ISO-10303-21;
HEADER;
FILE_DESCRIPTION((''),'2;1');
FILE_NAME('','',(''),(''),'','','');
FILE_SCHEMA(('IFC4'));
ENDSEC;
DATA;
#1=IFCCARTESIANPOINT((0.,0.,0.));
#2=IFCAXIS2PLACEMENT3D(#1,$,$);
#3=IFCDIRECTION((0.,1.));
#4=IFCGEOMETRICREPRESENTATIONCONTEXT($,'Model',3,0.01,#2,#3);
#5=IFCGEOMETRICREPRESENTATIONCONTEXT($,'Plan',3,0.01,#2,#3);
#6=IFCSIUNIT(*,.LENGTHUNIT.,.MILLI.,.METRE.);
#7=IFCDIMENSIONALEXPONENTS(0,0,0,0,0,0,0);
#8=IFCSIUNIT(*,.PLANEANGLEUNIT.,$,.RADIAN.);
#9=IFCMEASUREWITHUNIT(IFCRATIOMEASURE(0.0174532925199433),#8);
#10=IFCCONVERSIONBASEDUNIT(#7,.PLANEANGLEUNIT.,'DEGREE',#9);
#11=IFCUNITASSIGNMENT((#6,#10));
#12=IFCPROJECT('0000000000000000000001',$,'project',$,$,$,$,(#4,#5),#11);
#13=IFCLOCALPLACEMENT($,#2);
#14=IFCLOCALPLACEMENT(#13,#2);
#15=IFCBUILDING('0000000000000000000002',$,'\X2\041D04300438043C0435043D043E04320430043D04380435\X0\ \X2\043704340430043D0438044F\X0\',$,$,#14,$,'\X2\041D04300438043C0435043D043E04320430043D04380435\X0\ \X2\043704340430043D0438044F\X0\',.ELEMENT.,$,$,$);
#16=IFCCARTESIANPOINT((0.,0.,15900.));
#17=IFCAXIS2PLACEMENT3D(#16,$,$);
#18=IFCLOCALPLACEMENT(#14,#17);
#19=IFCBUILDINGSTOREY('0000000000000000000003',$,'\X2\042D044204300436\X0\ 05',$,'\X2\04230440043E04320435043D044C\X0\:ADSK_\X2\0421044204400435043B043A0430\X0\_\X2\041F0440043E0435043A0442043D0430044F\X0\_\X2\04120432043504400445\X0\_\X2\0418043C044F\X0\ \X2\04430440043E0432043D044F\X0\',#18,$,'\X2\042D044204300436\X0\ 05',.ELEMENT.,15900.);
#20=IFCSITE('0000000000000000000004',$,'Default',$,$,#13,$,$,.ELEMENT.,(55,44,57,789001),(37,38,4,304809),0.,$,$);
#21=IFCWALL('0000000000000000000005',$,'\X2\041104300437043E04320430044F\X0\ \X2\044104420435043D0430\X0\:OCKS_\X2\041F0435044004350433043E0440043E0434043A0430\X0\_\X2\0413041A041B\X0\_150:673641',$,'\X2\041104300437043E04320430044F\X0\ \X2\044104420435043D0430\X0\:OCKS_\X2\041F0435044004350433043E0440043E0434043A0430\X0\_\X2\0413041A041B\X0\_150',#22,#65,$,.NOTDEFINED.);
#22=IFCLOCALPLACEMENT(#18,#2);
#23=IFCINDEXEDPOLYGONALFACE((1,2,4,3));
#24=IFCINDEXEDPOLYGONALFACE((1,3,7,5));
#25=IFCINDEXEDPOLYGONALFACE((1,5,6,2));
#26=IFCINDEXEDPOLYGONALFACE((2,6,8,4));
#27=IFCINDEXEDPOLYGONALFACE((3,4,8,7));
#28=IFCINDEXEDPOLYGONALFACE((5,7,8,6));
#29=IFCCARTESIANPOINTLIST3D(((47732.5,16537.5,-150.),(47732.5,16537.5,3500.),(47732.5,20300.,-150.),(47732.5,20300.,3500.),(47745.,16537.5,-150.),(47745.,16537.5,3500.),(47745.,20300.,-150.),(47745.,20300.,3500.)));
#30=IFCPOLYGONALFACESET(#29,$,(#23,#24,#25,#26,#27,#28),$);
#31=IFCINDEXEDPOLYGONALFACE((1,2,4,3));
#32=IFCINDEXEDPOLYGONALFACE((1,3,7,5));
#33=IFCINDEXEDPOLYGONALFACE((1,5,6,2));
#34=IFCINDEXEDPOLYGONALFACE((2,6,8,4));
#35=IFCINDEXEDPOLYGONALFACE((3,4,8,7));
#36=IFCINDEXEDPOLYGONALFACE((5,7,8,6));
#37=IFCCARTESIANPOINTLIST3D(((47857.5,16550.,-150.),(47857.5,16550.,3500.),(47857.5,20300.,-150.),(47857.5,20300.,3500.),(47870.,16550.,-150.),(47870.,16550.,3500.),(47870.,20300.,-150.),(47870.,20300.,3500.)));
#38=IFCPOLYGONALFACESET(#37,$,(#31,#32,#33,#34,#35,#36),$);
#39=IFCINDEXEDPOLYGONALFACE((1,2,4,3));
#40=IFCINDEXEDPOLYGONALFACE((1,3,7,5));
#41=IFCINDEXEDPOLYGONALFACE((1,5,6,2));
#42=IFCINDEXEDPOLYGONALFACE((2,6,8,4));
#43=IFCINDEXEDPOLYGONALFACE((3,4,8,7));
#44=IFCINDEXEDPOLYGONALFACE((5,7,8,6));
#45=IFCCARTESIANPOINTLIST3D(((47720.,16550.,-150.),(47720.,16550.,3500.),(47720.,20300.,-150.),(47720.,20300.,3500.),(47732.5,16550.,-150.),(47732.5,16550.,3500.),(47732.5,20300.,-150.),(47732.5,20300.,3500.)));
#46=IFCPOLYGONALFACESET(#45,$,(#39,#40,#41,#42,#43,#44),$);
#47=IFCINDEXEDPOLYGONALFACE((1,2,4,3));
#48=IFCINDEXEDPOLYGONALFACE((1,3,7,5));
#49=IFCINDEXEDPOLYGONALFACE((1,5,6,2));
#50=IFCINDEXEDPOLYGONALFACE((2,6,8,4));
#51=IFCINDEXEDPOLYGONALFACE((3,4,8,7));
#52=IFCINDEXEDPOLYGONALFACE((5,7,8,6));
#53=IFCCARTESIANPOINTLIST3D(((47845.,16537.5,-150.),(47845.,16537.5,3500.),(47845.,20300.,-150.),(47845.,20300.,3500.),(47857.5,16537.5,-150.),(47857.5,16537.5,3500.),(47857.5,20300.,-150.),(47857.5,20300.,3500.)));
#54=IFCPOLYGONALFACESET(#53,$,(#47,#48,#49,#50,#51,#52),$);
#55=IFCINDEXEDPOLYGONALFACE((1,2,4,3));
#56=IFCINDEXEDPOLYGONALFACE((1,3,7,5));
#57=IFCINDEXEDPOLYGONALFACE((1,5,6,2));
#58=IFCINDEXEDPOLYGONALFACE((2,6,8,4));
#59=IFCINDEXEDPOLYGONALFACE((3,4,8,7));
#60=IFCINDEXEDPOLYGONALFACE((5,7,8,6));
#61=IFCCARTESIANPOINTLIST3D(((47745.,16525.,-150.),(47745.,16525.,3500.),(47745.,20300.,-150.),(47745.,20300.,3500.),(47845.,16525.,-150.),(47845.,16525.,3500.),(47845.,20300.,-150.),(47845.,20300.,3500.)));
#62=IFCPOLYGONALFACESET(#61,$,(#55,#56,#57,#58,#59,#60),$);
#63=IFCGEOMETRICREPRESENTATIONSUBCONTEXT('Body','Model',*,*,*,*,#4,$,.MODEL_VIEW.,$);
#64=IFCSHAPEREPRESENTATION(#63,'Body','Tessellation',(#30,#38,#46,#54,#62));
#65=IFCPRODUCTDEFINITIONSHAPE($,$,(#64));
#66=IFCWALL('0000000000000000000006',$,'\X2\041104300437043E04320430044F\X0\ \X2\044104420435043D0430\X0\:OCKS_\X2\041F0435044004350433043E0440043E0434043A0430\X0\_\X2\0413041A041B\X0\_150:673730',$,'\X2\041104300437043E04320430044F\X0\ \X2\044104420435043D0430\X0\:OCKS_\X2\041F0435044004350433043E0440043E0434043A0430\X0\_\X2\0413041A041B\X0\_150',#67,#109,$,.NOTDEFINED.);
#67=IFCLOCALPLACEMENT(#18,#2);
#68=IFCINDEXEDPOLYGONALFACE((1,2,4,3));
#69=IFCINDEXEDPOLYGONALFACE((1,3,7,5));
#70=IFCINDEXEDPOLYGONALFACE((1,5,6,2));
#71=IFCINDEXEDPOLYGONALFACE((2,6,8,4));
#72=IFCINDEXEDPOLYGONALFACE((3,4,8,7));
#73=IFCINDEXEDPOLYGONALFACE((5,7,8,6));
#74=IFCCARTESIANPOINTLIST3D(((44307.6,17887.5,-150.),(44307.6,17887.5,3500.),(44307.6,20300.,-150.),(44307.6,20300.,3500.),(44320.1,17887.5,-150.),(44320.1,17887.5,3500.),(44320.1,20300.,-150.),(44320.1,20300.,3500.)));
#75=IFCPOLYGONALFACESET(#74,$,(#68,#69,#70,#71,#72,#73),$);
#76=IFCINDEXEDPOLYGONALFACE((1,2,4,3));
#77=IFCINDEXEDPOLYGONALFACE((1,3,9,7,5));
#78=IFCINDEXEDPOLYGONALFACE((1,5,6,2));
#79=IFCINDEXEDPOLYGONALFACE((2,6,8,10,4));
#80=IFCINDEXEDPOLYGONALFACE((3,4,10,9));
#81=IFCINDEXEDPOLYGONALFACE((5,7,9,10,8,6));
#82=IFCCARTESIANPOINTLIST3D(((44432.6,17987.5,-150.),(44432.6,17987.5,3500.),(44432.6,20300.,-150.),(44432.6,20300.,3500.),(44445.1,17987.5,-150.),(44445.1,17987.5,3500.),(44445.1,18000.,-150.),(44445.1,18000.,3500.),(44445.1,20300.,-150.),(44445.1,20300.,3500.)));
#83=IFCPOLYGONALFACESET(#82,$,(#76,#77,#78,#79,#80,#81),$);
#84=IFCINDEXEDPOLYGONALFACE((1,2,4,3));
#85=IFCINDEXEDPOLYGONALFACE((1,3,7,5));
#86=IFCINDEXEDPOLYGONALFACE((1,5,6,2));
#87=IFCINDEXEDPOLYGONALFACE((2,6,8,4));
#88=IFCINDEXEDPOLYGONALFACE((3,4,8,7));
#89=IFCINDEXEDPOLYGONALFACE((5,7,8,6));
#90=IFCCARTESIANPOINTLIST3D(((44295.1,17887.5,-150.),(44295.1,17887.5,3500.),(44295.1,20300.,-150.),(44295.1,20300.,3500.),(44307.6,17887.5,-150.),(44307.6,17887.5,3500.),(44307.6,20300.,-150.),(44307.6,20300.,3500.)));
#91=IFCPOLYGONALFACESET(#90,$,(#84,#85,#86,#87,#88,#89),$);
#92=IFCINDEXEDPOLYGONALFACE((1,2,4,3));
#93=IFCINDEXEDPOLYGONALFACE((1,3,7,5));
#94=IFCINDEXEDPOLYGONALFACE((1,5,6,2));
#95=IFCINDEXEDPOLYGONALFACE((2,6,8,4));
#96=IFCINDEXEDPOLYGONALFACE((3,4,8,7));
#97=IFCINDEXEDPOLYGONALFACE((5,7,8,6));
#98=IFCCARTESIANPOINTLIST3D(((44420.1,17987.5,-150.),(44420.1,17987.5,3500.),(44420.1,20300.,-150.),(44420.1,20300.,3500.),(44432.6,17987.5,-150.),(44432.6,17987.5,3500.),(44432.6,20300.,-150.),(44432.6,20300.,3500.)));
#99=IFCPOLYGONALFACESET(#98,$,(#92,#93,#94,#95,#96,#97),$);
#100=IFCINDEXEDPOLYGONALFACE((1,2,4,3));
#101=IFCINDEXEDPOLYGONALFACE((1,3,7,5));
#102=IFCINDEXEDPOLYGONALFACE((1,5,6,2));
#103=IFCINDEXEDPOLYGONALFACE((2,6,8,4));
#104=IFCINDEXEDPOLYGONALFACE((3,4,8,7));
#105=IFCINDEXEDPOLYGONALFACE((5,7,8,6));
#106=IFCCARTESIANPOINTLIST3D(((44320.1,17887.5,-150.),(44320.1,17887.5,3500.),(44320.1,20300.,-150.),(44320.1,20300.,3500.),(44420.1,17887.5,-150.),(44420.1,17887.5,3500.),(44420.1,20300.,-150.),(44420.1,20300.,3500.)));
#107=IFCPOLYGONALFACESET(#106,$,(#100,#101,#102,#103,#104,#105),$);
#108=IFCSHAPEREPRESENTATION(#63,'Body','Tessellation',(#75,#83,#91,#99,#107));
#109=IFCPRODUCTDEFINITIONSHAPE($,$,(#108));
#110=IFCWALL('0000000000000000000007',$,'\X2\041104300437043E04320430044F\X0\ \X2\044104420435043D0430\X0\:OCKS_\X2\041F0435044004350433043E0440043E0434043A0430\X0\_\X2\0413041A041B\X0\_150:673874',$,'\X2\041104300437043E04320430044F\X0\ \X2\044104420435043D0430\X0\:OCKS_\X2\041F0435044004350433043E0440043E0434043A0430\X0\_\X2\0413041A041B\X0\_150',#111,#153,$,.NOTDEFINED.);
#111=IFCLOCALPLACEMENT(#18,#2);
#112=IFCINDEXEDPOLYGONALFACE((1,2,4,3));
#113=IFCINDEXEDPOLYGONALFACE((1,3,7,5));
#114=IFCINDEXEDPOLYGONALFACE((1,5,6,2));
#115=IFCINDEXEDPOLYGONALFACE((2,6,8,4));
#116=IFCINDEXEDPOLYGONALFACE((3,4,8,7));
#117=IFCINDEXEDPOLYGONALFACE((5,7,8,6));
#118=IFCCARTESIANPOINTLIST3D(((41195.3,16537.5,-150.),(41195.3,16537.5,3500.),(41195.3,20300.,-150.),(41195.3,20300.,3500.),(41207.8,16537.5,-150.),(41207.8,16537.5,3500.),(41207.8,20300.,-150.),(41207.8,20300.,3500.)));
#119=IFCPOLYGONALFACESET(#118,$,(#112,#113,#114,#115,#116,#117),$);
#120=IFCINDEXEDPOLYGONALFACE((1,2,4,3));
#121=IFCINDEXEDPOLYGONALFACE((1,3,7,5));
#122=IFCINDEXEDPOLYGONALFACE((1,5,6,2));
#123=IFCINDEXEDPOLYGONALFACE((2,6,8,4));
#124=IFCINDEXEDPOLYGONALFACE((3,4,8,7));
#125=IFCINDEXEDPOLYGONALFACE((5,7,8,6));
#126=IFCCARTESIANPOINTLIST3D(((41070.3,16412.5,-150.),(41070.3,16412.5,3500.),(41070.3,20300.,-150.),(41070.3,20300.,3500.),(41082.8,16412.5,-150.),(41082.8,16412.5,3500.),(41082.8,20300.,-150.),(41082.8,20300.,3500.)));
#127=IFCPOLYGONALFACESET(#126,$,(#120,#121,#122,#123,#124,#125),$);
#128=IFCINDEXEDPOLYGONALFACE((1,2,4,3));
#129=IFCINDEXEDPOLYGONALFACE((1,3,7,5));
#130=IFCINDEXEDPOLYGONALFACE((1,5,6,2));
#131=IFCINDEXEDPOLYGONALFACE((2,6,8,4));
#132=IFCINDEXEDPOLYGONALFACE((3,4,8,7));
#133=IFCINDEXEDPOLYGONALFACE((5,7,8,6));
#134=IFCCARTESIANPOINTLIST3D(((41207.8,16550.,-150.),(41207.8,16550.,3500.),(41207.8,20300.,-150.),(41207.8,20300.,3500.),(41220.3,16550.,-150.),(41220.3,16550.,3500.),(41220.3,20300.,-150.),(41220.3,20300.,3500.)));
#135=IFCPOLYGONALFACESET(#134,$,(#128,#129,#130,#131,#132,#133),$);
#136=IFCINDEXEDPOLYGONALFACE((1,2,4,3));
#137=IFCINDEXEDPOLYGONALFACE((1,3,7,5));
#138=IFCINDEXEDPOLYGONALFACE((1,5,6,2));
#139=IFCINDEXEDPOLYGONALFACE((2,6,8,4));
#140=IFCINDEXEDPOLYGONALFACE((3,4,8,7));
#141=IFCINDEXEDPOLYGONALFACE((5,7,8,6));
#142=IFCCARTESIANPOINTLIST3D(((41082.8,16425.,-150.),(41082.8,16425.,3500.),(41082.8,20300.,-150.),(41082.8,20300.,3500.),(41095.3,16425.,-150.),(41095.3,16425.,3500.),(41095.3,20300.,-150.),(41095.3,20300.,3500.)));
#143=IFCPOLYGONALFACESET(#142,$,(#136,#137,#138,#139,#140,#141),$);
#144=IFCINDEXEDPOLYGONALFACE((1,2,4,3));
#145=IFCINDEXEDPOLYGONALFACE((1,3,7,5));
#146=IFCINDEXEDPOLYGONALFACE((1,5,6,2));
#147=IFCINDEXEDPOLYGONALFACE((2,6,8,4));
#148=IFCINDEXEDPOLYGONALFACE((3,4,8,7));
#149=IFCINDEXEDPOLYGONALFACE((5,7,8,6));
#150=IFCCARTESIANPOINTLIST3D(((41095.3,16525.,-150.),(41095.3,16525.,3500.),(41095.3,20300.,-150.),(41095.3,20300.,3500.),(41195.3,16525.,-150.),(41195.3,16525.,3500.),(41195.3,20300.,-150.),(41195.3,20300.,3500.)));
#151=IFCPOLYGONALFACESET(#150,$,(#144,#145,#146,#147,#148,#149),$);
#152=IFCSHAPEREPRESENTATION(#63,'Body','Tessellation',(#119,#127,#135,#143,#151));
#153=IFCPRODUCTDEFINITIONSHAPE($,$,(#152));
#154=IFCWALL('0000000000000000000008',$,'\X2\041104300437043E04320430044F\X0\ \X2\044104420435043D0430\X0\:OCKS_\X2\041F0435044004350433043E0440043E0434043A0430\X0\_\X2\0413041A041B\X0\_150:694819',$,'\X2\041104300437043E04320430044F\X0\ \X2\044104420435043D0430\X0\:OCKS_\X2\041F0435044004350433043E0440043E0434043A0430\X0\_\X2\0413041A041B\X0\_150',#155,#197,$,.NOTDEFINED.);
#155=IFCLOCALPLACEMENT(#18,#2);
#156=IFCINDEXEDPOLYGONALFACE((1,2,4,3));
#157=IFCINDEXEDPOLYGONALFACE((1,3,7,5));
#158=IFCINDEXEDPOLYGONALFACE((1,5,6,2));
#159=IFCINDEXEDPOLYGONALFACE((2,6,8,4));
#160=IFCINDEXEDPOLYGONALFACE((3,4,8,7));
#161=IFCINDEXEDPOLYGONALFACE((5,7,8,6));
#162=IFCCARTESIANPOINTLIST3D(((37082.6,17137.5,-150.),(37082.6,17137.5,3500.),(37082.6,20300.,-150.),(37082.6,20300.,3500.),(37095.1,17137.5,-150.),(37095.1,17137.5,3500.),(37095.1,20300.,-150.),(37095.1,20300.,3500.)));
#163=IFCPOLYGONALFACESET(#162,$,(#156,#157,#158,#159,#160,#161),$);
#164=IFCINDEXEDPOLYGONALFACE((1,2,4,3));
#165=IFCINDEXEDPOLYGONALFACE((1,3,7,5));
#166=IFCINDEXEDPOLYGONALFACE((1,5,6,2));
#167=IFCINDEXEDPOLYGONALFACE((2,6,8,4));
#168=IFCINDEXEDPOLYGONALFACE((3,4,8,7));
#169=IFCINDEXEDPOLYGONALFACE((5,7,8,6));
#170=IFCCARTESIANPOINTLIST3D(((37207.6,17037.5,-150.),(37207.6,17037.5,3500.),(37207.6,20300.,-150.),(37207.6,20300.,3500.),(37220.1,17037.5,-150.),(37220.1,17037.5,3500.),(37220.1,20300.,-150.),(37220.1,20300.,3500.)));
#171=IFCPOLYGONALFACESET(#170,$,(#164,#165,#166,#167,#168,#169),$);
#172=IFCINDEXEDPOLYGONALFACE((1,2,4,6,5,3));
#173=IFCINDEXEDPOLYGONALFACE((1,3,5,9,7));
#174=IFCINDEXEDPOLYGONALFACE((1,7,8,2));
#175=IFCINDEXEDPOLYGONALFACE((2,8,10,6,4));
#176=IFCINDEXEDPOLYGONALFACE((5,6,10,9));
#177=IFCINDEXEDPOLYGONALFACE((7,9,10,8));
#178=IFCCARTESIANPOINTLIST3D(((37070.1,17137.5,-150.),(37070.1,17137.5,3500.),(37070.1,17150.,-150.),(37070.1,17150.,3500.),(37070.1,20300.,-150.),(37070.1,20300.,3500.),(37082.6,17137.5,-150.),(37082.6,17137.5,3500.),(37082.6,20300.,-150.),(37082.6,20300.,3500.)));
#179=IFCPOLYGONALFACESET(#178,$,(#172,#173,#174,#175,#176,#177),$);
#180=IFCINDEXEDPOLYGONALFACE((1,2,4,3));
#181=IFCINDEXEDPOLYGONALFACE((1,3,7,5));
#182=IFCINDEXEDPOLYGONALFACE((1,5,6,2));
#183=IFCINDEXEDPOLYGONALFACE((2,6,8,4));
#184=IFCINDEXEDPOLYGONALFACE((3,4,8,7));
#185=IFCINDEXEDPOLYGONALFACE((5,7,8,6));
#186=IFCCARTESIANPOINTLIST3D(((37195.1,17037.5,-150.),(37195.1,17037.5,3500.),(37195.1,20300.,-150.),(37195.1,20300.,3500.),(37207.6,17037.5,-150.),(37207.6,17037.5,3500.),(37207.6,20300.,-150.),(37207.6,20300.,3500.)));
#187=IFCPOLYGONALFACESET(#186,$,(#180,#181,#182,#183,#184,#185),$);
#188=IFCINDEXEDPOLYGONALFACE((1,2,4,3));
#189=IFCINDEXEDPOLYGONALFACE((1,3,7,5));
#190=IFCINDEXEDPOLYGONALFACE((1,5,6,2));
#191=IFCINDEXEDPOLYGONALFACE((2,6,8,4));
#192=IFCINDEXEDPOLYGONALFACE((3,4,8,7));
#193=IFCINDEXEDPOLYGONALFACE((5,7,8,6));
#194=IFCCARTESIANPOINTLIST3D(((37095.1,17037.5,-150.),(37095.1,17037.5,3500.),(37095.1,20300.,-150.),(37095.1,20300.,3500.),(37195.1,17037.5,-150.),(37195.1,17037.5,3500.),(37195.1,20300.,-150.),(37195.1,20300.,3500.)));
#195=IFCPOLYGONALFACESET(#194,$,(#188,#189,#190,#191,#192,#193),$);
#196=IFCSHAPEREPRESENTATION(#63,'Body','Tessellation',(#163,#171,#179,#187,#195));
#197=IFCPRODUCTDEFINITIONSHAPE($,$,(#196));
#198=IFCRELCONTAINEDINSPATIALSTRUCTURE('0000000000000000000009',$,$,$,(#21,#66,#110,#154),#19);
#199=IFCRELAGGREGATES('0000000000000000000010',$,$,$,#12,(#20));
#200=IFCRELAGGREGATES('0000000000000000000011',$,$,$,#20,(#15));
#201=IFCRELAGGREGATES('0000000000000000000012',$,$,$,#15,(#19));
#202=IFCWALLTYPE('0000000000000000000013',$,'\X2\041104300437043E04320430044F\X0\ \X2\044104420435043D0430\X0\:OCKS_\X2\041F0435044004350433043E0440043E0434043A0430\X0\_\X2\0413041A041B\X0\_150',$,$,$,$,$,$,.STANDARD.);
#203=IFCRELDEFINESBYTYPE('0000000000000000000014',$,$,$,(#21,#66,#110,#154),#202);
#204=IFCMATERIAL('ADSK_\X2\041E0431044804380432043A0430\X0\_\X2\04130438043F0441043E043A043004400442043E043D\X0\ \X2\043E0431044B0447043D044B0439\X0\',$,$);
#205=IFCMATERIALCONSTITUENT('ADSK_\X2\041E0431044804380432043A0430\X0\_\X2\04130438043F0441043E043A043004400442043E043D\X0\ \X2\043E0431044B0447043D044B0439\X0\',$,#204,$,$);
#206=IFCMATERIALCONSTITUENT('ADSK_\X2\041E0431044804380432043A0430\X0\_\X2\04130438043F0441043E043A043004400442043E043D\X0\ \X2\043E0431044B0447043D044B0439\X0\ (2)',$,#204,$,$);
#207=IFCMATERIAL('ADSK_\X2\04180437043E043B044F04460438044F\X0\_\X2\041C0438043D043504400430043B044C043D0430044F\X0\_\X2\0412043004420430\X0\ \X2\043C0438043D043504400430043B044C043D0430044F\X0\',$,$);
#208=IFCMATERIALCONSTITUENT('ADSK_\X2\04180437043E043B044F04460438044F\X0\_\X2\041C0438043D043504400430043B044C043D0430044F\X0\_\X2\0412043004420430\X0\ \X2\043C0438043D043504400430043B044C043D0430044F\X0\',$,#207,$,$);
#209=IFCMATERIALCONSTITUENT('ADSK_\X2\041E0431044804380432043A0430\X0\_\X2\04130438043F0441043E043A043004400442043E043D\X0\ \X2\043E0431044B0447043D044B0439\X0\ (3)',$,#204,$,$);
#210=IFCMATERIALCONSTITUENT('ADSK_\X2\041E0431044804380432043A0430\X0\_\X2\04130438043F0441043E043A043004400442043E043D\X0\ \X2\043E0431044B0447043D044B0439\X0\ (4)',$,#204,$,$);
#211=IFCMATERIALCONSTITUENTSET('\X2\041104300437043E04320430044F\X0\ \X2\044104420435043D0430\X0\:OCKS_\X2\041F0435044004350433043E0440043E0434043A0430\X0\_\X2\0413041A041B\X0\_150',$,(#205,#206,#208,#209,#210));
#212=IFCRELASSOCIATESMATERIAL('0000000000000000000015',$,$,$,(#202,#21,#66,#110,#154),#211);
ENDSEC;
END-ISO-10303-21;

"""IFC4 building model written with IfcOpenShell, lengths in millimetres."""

from ifc_helpers import new_model, entity, si_unit, converted_unit, direction, frame, origin, place, context, subcontext, project, spatial, indexed_curve, outline, extrude, material, constituent, constituent_set, type_object, element, save


model = new_model("IFC4")

# Units and contexts
model_context = context("Model", 3, precision=0.01, world=origin(), true_north=direction((0.0, 1.0)))
plan_context = context("Plan", 3, precision=0.01, world=origin(), true_north=direction((0.0, 1.0)))
body_context = subcontext(model_context, "Body", "Model", "MODEL_VIEW")
ifc_project = project(units=[si_unit("LENGTHUNIT", "METRE", prefix="MILLI"), converted_unit("PLANEANGLEUNIT", "DEGREE", entity("IfcRatioMeasure", 0.0174532925199433), si_unit("PLANEANGLEUNIT", "RADIAN"), dimensions=[0, 0, 0, 0, 0, 0, 0])], contexts=[model_context, plan_context])

# Site, building, storey
site_placement = place(None, frame((0.0, 0.0, 0.0)))
site = spatial("IfcSite", under=ifc_project, at=site_placement, Name="Default", CompositionType="ELEMENT", RefLatitude=(55, 44, 57, 789001), RefLongitude=(37, 38, 4, 304809), RefElevation=0.0)
building_placement = place(site_placement, origin())
building = spatial("IfcBuilding", under=site, at=building_placement, Name="Наименование здания", LongName="Наименование здания", CompositionType="ELEMENT")
storey_placement = place(building_placement, frame((0.0, 0.0, 15900.0)))
storey = spatial("IfcBuildingStorey", under=building, at=storey_placement, Name="Этаж 05", ObjectType="Уровень:ADSK_Стрелка_Проектная_Вверх_Имя уровня", LongName="Этаж 05", CompositionType="ELEMENT", Elevation=15900.0)

# Walls
ifc_material_1 = material(Name="ADSK_Обшивка_Гипсокартон обычный")
ifc_constituent_1 = constituent(ifc_material_1, Name="ADSK_Обшивка_Гипсокартон обычный")
ifc_constituent_2 = constituent(ifc_material_1, Name="ADSK_Обшивка_Гипсокартон обычный (2)")
ifc_material_2 = material(Name="ADSK_Изоляция_Минеральная_Вата минеральная")
ifc_constituent_3 = constituent(ifc_material_2, Name="ADSK_Изоляция_Минеральная_Вата минеральная")
ifc_constituent_4 = constituent(ifc_material_1, Name="ADSK_Обшивка_Гипсокартон обычный (3)")
ifc_constituent_5 = constituent(ifc_material_1, Name="ADSK_Обшивка_Гипсокартон обычный (4)")
ifc_constituent_set_1 = constituent_set(constituents=[ifc_constituent_1, ifc_constituent_2, ifc_constituent_3, ifc_constituent_4, ifc_constituent_5], Name="Базовая стена:OCKS_Перегородка_ГКЛ_150")
wall_type_1 = type_object("IfcWallType", Name="Базовая стена:OCKS_Перегородка_ГКЛ_150", PredefinedType="STANDARD", material=ifc_constituent_set_1)
wall_1_placement = place(storey_placement, frame((47795.0, 16550.0, -150.0), z_axis=(0.0, 0.0, 1.0), x_axis=(0.0, 1.0, 0.0)))
element("IfcWall", 1, at=wall_1_placement, inside=storey, type_object=wall_type_1, material=ifc_constituent_set_1, Name="Базовая стена:OCKS_Перегородка_ГКЛ_150:673641", ObjectType="Базовая стена:OCKS_Перегородка_ГКЛ_150", PredefinedType="NOTDEFINED", context=body_context, shape_type="SweptSolid", body=[
    extrude(outline(indexed_curve([(-1881.3, -6.3), (1881.3, -6.3), (1881.3, 6.2), (-1881.3, 6.2), (-1881.3, -6.3)], self_intersect=False)), frame((1868.8, 56.3, 0.0)), (0.0, 0.0, 1.0), 3650.0),
    extrude(outline(indexed_curve([(-6.3, -1875.0), (6.2, -1875.0), (6.3, 1875.0), (-6.2, 1875.0), (-6.3, -1875.0)], self_intersect=False)), frame((1875.0, -68.7, 0.0), z_axis=(0.0, 0.0, 1.0), x_axis=(0.0, 1.0, 0.0)), (0.0, 0.0, 1.0), 3650.0),
    extrude(outline(indexed_curve([(-6.3, -1875.0), (6.2, -1875.0), (6.3, 1875.0), (-6.2, 1875.0), (-6.3, -1875.0)], self_intersect=False)), frame((1875.0, 68.8, 0.0), z_axis=(0.0, 0.0, 1.0), x_axis=(0.0, -1.0, 0.0)), (0.0, 0.0, 1.0), 3650.0),
    extrude(outline(indexed_curve([(-1881.3, -6.3), (1881.3, -6.3), (1881.3, 6.2), (-1881.3, 6.2), (-1881.3, -6.3)], self_intersect=False)), frame((1868.8, -56.2, 0.0)), (0.0, 0.0, 1.0), 3650.0),
    extrude(outline(indexed_curve([(-1887.5, -50.0), (1887.5, -50.0), (1887.5, 50.0), (-1887.5, 50.0), (-1887.5, -50.0)], self_intersect=False)), frame((1862.5, 0.0, 0.0)), (0.0, 0.0, 1.0), 3650.0),
])
wall_2_placement = place(storey_placement, frame((44370.1, 20300.0, -150.0), z_axis=(0.0, 0.0, 1.0), x_axis=(0.0, -1.0, 0.0)))
element("IfcWall", 2, at=wall_2_placement, inside=storey, type_object=wall_type_1, material=ifc_constituent_set_1, Name="Базовая стена:OCKS_Перегородка_ГКЛ_150:673730", ObjectType="Базовая стена:OCKS_Перегородка_ГКЛ_150", PredefinedType="NOTDEFINED", context=body_context, shape_type="SweptSolid", body=[
    extrude(outline(indexed_curve([(-1206.2, -6.3), (1206.2, -6.3), (1206.2, 6.3), (-1206.2, 6.3), (-1206.2, -6.3)], self_intersect=False)), frame((1206.2, -56.3, 0.0)), (0.0, 0.0, 1.0), 3650.0),
    extrude(outline(indexed_curve([(-915.0, -5.0), (1385.0, -5.0), (1385.0, 7.5), (-927.5, 7.5), (-927.5, -5.0), (-915.0, -5.0)], self_intersect=False)), frame((1385.0, 70.0, 0.0), z_axis=(0.0, 0.0, 1.0), x_axis=(-1.0, 0.0, 0.0)), (0.0, 0.0, 1.0), 3650.0),
    extrude(outline(indexed_curve([(-6.3, -1206.2), (6.2, -1206.2), (6.2, 1206.2), (-6.3, 1206.2), (-6.3, -1206.2)], self_intersect=False)), frame((1206.2, -68.7, 0.0), z_axis=(0.0, 0.0, 1.0), x_axis=(0.0, 1.0, 0.0)), (0.0, 0.0, 1.0), 3650.0),
    extrude(outline(indexed_curve([(-1156.2, -6.3), (1156.2, -6.3), (1156.2, 6.3), (-1156.2, 6.3), (-1156.2, -6.3)], self_intersect=False)), frame((1156.2, 56.3, 0.0)), (0.0, 0.0, 1.0), 3650.0),
    extrude(outline(indexed_curve([(-1206.2, -50.0), (1206.2, -50.0), (1206.2, 50.0), (-1206.2, 50.0), (-1206.2, -50.0)], self_intersect=False)), frame((1206.2, 0.0, 0.0)), (0.0, 0.0, 1.0), 3650.0),
])

# Wall
wall_3_placement = place(storey_placement, frame((41145.3, 16550.0, -150.0), z_axis=(0.0, 0.0, 1.0), x_axis=(0.0, 1.0, 0.0)))
element("IfcWall", 3, at=wall_3_placement, inside=storey, type_object=wall_type_1, material=ifc_constituent_set_1, Name="Базовая стена:OCKS_Перегородка_ГКЛ_150:673874", ObjectType="Базовая стена:OCKS_Перегородка_ГКЛ_150", PredefinedType="NOTDEFINED", context=body_context, shape_type="SweptSolid", body=[
    extrude(outline(indexed_curve([(-1881.3, -6.3), (1881.3, -6.3), (1881.3, 6.2), (-1881.3, 6.2), (-1881.3, -6.3)], self_intersect=False)), frame((1868.8, -56.2, 0.0)), (0.0, 0.0, 1.0), 3650.0),
    extrude(outline(indexed_curve([(-6.2, -1943.8), (6.3, -1943.8), (6.3, 1943.8), (-6.2, 1943.8), (-6.2, -1943.8)], self_intersect=False)), frame((1806.3, 68.8, 0.0), z_axis=(0.0, 0.0, 1.0), x_axis=(0.0, -1.0, 0.0)), (0.0, 0.0, 1.0), 3650.0),
    extrude(outline(indexed_curve([(-6.3, -1875.0), (6.2, -1875.0), (6.3, 1875.0), (-6.2, 1875.0), (-6.3, -1875.0)], self_intersect=False)), frame((1875.0, -68.7, 0.0), z_axis=(0.0, 0.0, 1.0), x_axis=(0.0, 1.0, 0.0)), (0.0, 0.0, 1.0), 3650.0),
    extrude(outline(indexed_curve([(-1937.5, -6.3), (1937.5, -6.3), (1937.5, 6.2), (-1937.5, 6.2), (-1937.5, -6.3)], self_intersect=False)), frame((1812.5, 56.3, 0.0)), (0.0, 0.0, 1.0), 3650.0),
    extrude(outline(indexed_curve([(-1887.5, -50.0), (1887.5, -50.0), (1887.5, 50.0), (-1887.5, 50.0), (-1887.5, -50.0)], self_intersect=False)), frame((1862.5, 0.0, 0.0)), (0.0, 0.0, 1.0), 3650.0),
])

# Wall
wall_4_placement = place(storey_placement, frame((37145.1, 20300.0, -150.0), z_axis=(0.0, 0.0, 1.0), x_axis=(0.0, -1.0, 0.0)))
element("IfcWall", 4, at=wall_4_placement, inside=storey, type_object=wall_type_1, material=ifc_constituent_set_1, Name="Базовая стена:OCKS_Перегородка_ГКЛ_150:694819", ObjectType="Базовая стена:OCKS_Перегородка_ГКЛ_150", PredefinedType="NOTDEFINED", context=body_context, shape_type="SweptSolid", body=[
    extrude(outline(indexed_curve([(-1581.3, -6.2), (1581.3, -6.2), (1581.3, 6.3), (-1581.3, 6.3), (-1581.3, -6.2)], self_intersect=False)), frame((1581.3, -56.3, 0.0)), (0.0, 0.0, 1.0), 3650.0),
    extrude(outline(indexed_curve([(-6.3, -1631.3), (6.2, -1631.3), (6.2, 1631.3), (-6.3, 1631.3), (-6.3, -1631.3)], self_intersect=False)), frame((1631.3, 68.7, 0.0), z_axis=(0.0, 0.0, 1.0), x_axis=(0.0, -1.0, 0.0)), (0.0, 0.0, 1.0), 3650.0),
    extrude(outline(indexed_curve([(1255.0, -5.0), (1267.5, -5.0), (1267.5, 7.5), (-1895.0, 7.5), (-1895.0, -5.0), (1255.0, -5.0)], self_intersect=False)), frame((1895.0, -70.0, 0.0)), (0.0, 0.0, 1.0), 3650.0),
    extrude(outline(indexed_curve([(-1631.3, -6.3), (1631.3, -6.3), (1631.3, 6.2), (-1631.3, 6.2), (-1631.3, -6.3)], self_intersect=False)), frame((1631.3, 56.3, 0.0)), (0.0, 0.0, 1.0), 3650.0),
    extrude(outline(indexed_curve([(-1631.3, -50.0), (1631.3, -50.0), (1631.3, 50.0), (-1631.3, 50.0), (-1631.3, -50.0)], self_intersect=False)), frame((1631.3, 0.0, 0.0)), (0.0, 0.0, 1.0), 3650.0),
])

save(model, "model.ifc")
